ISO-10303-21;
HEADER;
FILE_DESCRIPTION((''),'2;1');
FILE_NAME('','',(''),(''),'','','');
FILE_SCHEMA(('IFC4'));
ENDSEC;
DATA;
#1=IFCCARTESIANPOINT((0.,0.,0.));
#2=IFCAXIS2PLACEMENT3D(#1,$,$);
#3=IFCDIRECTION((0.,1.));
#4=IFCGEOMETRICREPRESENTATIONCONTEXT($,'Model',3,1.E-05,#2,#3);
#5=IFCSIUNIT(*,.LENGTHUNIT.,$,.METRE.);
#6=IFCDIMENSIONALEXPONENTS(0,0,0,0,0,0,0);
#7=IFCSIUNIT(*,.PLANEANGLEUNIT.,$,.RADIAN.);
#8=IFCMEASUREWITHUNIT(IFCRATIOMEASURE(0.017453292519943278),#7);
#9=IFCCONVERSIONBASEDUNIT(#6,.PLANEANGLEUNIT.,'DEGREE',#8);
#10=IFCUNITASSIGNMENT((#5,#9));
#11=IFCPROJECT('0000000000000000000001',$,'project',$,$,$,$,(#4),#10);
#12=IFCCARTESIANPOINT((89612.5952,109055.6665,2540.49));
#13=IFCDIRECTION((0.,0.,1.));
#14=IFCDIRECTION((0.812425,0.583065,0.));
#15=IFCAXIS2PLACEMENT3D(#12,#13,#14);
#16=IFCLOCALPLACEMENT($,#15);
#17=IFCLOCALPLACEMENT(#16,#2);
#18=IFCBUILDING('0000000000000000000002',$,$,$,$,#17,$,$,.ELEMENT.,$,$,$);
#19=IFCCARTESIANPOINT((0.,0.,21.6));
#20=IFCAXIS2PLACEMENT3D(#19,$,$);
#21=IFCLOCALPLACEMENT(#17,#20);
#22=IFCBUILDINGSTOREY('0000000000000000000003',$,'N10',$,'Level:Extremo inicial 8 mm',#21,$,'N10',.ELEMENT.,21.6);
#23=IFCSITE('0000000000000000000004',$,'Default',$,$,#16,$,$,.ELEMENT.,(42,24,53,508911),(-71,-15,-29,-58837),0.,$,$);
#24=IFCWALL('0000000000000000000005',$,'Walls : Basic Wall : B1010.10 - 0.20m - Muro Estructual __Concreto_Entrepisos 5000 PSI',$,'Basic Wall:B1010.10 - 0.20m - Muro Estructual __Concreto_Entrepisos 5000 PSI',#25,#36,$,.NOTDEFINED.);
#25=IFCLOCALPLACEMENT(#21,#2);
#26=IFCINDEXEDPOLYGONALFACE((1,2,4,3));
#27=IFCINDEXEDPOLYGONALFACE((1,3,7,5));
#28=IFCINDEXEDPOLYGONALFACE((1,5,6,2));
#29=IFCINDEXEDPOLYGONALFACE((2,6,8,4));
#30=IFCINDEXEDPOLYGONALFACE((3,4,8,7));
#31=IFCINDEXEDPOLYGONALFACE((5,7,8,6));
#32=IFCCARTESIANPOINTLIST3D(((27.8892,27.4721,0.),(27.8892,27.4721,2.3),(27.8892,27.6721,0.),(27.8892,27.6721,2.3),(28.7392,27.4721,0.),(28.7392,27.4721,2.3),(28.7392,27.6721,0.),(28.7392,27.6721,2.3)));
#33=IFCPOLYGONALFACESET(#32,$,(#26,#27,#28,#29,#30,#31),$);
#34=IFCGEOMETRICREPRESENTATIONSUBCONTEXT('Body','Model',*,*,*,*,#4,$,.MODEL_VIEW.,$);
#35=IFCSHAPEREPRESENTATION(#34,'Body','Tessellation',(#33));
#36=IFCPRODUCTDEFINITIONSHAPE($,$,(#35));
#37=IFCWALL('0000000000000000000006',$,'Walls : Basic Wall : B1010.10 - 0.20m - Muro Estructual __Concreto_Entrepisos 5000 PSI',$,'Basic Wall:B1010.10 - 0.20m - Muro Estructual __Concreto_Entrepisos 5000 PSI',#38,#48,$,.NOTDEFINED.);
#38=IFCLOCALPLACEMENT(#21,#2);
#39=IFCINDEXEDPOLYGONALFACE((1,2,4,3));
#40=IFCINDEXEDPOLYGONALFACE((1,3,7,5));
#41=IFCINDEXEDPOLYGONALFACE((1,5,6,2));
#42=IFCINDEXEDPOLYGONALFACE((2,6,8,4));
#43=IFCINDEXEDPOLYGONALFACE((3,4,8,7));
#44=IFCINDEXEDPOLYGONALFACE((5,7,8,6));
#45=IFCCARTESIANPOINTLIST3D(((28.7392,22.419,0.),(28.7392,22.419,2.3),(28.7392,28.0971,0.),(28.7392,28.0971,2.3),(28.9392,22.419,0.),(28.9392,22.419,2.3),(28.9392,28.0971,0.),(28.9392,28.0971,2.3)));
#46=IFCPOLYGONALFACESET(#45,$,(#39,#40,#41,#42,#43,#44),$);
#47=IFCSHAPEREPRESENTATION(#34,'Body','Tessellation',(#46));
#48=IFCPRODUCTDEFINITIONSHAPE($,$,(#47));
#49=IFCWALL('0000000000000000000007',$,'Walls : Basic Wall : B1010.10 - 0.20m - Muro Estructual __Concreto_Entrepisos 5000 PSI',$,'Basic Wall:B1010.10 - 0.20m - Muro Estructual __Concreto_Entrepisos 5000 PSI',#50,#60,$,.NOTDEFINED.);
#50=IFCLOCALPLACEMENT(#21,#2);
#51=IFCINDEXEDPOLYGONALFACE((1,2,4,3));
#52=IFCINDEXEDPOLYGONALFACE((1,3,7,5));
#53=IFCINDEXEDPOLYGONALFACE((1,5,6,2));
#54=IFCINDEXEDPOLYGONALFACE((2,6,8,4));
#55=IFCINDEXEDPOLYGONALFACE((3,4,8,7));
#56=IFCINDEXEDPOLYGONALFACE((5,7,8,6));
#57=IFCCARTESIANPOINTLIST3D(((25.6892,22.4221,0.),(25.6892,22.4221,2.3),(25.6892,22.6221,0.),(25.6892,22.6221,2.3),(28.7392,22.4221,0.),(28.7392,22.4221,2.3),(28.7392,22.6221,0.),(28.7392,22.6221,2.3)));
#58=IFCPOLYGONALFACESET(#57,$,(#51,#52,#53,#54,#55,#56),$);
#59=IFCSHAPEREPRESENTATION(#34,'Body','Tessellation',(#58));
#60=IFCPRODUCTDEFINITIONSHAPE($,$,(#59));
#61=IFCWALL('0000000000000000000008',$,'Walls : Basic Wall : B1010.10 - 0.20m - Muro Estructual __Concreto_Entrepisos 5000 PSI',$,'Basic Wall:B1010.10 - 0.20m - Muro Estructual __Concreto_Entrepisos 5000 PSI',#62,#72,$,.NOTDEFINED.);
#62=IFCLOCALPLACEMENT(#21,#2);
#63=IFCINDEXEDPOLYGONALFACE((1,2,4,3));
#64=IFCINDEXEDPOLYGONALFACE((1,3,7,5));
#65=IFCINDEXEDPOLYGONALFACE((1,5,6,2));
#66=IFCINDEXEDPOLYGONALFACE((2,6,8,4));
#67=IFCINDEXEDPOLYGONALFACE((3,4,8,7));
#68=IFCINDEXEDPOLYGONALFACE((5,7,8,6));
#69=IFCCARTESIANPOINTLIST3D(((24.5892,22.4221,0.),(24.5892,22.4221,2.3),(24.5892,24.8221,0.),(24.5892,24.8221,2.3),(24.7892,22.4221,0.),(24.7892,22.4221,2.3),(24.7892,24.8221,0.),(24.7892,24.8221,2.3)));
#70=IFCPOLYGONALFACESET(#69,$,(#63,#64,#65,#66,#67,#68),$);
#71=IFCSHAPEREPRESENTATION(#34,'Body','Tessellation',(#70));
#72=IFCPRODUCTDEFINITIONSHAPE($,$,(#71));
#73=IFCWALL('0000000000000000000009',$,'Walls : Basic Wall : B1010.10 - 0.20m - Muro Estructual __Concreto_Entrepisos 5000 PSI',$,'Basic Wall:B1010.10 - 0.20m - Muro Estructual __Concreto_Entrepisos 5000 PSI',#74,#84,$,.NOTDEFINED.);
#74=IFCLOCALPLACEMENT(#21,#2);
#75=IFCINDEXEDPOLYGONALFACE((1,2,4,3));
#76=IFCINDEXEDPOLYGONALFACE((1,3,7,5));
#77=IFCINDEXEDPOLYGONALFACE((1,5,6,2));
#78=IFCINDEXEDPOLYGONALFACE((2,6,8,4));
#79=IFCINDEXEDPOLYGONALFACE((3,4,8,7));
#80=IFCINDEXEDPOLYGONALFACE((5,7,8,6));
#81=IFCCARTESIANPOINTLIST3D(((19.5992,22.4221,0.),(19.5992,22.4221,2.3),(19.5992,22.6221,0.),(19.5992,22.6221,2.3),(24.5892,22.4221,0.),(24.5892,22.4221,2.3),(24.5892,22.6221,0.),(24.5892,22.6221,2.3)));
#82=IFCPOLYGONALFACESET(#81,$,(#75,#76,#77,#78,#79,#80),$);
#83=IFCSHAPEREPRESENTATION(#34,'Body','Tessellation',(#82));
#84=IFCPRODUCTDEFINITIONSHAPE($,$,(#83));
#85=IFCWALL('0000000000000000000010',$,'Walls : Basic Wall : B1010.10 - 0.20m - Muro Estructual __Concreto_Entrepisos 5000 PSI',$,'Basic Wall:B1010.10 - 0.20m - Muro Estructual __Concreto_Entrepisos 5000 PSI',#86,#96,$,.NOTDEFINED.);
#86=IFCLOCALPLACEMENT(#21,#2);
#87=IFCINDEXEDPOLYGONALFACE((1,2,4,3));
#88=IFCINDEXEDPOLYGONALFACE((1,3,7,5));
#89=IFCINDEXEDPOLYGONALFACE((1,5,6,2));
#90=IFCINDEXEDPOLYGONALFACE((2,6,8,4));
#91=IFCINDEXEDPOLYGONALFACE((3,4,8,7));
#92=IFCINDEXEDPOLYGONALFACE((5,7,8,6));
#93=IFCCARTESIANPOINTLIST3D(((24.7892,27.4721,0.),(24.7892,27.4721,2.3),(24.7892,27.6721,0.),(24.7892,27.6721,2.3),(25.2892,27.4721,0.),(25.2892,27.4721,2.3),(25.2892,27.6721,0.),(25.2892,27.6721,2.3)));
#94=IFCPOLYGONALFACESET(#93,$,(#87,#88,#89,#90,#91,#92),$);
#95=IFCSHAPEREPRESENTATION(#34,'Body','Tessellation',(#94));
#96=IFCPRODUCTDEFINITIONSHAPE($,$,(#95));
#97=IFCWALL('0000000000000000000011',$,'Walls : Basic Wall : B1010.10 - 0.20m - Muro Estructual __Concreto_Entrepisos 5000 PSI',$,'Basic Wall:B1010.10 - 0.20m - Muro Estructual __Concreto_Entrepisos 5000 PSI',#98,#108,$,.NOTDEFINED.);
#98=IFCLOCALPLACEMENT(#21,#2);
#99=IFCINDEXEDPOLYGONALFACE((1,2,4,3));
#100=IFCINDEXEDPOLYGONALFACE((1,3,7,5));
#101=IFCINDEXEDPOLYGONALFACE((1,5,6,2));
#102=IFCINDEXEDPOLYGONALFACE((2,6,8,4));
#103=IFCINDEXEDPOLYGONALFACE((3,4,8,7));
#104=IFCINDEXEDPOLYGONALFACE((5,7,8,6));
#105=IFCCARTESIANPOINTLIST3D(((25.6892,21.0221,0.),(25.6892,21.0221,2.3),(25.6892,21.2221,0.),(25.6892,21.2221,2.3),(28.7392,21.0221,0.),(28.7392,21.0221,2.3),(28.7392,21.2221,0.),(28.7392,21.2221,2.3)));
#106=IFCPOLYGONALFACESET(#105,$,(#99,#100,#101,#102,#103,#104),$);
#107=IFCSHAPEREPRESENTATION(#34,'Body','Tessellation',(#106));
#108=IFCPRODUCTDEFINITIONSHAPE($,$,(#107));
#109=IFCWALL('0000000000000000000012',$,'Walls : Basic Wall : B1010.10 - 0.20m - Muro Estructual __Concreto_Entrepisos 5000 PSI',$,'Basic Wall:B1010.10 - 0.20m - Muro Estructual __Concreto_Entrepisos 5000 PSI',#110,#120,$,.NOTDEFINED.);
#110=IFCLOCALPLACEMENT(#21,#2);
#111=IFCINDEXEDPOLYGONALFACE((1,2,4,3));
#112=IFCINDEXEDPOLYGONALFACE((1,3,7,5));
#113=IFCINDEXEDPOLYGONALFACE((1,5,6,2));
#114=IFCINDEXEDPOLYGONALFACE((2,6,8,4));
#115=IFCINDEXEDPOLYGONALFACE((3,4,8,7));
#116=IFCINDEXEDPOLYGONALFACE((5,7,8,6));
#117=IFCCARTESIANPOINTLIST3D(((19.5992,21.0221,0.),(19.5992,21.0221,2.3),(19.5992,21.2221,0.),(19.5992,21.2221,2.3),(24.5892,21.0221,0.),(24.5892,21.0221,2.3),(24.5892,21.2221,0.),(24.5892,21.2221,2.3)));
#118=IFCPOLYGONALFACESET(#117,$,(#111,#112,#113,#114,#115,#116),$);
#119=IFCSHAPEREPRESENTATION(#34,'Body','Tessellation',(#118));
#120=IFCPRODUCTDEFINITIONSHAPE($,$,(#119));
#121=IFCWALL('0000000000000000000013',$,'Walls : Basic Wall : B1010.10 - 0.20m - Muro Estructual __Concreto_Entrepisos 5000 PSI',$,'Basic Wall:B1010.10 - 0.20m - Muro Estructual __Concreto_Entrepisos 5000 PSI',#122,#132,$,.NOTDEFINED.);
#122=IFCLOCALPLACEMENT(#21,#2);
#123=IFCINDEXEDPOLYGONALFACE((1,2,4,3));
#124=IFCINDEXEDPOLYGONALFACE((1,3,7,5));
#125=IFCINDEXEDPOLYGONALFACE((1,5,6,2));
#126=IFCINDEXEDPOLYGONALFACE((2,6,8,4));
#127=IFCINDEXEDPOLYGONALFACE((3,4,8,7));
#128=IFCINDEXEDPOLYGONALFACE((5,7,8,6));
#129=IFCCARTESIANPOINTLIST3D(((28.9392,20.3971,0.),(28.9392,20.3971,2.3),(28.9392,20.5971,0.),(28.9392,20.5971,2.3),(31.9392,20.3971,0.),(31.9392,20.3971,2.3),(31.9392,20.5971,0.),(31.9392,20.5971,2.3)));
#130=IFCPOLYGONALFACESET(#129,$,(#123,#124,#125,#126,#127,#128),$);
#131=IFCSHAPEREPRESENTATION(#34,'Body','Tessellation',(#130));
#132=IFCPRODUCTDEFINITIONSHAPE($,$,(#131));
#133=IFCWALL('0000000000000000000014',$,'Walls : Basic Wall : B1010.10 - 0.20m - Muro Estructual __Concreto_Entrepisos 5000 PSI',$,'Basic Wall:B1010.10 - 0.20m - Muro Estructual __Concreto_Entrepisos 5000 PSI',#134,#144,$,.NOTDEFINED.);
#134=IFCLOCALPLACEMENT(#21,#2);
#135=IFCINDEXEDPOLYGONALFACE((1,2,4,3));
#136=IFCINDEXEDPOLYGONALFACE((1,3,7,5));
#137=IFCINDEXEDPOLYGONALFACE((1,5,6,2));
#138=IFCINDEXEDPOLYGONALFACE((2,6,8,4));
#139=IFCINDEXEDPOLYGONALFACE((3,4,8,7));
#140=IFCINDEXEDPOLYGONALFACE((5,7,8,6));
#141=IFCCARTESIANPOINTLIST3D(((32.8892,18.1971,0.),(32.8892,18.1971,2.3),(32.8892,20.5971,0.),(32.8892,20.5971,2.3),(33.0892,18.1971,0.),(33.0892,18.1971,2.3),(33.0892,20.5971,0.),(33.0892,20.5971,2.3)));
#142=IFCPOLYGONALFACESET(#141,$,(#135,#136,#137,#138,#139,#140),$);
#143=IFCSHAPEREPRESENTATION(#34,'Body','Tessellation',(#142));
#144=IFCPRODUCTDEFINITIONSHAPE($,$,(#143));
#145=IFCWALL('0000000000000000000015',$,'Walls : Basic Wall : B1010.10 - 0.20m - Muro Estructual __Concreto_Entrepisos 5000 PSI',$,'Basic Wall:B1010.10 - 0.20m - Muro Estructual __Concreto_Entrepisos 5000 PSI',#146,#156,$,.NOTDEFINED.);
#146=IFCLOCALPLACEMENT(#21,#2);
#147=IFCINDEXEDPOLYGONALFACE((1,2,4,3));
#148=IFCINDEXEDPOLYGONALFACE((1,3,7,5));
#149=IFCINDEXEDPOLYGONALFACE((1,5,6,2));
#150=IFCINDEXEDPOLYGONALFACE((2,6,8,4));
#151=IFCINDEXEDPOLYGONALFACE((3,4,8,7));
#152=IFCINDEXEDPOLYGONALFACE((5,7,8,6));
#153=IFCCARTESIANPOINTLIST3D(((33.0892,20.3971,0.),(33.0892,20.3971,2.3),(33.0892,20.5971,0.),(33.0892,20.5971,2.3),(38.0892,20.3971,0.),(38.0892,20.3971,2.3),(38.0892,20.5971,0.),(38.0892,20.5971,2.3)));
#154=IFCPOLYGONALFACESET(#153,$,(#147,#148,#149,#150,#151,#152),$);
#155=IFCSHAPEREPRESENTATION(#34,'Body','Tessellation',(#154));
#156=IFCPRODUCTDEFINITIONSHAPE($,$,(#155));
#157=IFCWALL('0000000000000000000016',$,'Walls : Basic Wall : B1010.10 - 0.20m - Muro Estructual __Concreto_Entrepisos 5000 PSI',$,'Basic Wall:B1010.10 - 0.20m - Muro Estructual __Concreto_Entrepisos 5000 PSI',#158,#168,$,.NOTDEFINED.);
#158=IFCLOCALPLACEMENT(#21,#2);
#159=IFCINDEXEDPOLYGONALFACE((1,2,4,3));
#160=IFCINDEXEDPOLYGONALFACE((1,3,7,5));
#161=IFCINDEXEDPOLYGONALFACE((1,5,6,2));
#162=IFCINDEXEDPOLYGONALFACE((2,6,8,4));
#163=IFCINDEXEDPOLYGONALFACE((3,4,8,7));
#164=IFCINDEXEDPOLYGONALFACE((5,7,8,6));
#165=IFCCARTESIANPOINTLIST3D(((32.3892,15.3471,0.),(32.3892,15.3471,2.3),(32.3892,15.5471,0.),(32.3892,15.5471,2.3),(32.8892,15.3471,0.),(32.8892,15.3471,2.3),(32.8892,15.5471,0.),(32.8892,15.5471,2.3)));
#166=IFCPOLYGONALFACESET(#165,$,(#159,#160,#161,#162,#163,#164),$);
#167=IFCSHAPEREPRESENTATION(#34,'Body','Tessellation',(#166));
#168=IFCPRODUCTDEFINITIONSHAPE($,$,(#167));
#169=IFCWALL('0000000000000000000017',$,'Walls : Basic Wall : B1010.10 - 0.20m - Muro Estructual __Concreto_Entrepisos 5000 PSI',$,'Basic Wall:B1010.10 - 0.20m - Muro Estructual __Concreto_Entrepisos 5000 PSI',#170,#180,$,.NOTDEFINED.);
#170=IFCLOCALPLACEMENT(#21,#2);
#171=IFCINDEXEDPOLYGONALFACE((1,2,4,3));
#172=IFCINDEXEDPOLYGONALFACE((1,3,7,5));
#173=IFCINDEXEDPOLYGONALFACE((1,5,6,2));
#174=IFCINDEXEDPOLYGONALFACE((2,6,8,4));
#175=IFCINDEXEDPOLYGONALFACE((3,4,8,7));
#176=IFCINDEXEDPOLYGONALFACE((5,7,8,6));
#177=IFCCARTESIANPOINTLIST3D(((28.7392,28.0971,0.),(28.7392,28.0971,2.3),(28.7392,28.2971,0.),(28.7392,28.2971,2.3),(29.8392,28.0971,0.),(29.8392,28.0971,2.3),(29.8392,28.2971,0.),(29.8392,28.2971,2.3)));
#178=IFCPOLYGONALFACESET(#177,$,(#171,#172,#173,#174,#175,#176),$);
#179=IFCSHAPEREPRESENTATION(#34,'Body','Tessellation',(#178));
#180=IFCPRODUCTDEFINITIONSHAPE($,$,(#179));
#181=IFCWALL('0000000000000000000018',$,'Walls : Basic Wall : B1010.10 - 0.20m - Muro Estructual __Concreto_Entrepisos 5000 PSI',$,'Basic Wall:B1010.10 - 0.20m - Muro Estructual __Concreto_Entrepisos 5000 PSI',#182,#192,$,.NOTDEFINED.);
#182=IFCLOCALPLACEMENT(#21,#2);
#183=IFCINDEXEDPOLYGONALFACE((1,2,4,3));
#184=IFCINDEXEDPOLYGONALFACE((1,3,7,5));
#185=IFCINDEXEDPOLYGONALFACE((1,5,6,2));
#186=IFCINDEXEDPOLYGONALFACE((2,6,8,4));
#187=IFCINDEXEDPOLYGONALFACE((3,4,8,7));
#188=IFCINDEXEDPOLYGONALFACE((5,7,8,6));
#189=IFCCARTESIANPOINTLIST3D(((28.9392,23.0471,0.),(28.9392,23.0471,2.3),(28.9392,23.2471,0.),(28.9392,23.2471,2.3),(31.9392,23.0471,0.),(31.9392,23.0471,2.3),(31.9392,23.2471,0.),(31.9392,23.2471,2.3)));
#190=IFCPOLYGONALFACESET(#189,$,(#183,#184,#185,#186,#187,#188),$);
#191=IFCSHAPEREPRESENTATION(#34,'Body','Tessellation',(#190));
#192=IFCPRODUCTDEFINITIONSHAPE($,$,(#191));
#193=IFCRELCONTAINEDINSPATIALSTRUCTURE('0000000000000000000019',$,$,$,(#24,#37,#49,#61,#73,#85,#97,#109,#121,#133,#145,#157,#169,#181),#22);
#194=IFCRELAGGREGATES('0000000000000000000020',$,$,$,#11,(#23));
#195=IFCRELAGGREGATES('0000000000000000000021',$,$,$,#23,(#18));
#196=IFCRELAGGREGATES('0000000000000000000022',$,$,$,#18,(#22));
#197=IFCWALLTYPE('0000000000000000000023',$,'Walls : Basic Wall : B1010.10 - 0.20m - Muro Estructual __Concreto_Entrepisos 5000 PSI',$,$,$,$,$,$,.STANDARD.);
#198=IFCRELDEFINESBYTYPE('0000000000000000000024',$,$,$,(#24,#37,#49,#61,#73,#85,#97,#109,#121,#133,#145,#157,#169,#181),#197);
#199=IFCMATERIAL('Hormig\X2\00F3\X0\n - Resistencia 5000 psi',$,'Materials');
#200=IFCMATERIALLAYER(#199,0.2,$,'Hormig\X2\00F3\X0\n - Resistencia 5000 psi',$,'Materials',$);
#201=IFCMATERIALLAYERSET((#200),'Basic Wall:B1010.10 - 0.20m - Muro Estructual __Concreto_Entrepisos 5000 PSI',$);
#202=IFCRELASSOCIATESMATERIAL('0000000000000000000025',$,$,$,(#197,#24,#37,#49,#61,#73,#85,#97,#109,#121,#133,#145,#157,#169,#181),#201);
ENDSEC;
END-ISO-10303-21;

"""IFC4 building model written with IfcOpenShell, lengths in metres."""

from ifc_helpers import new_model, entity, si_unit, converted_unit, direction, frame, frame_2d, origin, place, context, subcontext, project, spatial, rectangle, extrude, material, layer, layer_set, layer_usage, type_object, element, save


model = new_model("IFC4")

# Units and contexts
model_context = context("Model", 3, precision=1e-05, world=origin(), true_north=direction((0.0, 1.0)))
body_context = subcontext(model_context, "Body", "Model", "MODEL_VIEW")
ifc_project = project(units=[si_unit("LENGTHUNIT", "METRE"), converted_unit("PLANEANGLEUNIT", "DEGREE", entity("IfcRatioMeasure", 0.017453292519943278), si_unit("PLANEANGLEUNIT", "RADIAN"), dimensions=[0, 0, 0, 0, 0, 0, 0])], contexts=[model_context])

# Site, building, storey
site_placement = place(None, frame((89612.5952, 109055.6665, 2540.49), z_axis=(0.0, 0.0, 1.0), x_axis=(0.812425, 0.583065, 0.0)))
site = spatial("IfcSite", under=ifc_project, at=site_placement, Name="Default", CompositionType="ELEMENT", RefLatitude=(42, 24, 53, 508911), RefLongitude=(-71, -15, -29, -58837), RefElevation=0.0)
building_placement = place(site_placement, origin())
building = spatial("IfcBuilding", under=site, at=building_placement, CompositionType="ELEMENT")
storey_placement = place(building_placement, frame((0.0, 0.0, 21.6)))
storey = spatial("IfcBuildingStorey", under=building, at=storey_placement, Name="N10", ObjectType="Level:Extremo inicial 8 mm", LongName="N10", CompositionType="ELEMENT", Elevation=21.6)

# Walls
ifc_material = material(Name="Hormigón - Resistencia 5000 psi", Category="Materials")
ifc_layer_1 = layer(ifc_material, 0.2, Name="Hormigón - Resistencia 5000 psi", Category="Materials")
ifc_layer_set_1 = layer_set([ifc_layer_1], Name="Basic Wall:B1010.10 - 0.20m - Muro Estructual __Concreto_Entrepisos 5000 PSI")
ifc_layer_usage_1 = layer_usage(ifc_layer_set_1, "AXIS2", "NEGATIVE", 0.1)
wall_type_1 = type_object("IfcWallType", Name="Walls : Basic Wall : B1010.10 - 0.20m - Muro Estructual __Concreto_Entrepisos 5000 PSI", PredefinedType="STANDARD", material=ifc_layer_set_1)
wall_1_placement = place(storey_placement, frame((27.8892, 27.5721, 0.0)))
element("IfcWall", 1, at=wall_1_placement, inside=storey, type_object=wall_type_1, material=ifc_layer_usage_1, Name="Walls : Basic Wall : B1010.10 - 0.20m - Muro Estructual __Concreto_Entrepisos 5000 PSI", ObjectType="Basic Wall:B1010.10 - 0.20m - Muro Estructual __Concreto_Entrepisos 5000 PSI", PredefinedType="NOTDEFINED", context=body_context, shape_type="SweptSolid", body=[
    extrude(rectangle(XDim=0.85, YDim=0.2, at=frame_2d((0.425, 0.0), x_axis=(-1.0, 0.0))), origin(), (0.0, 0.0, 1.0), 2.3),
])
ifc_layer_usage_2 = layer_usage(ifc_layer_set_1, "AXIS2", "NEGATIVE", 0.1)
wall_2_placement = place(storey_placement, frame((28.8392, 28.0971, 0.0), z_axis=(0.0, 0.0, 1.0), x_axis=(0.0, -1.0, 0.0)))
element("IfcWall", 2, at=wall_2_placement, inside=storey, type_object=wall_type_1, material=ifc_layer_usage_2, Name="Walls : Basic Wall : B1010.10 - 0.20m - Muro Estructual __Concreto_Entrepisos 5000 PSI", ObjectType="Basic Wall:B1010.10 - 0.20m - Muro Estructual __Concreto_Entrepisos 5000 PSI", PredefinedType="NOTDEFINED", context=body_context, shape_type="SweptSolid", body=[
    extrude(rectangle(XDim=5.6781, YDim=0.2, at=frame_2d((2.839, 0.0), x_axis=(-1.0, 0.0))), origin(), (0.0, 0.0, 1.0), 2.3),
])
ifc_layer_usage_3 = layer_usage(ifc_layer_set_1, "AXIS2", "NEGATIVE", 0.1)
wall_3_placement = place(storey_placement, frame((28.7392, 22.5221, 0.0), z_axis=(0.0, 0.0, 1.0), x_axis=(-1.0, 0.0, 0.0)))
element("IfcWall", 3, at=wall_3_placement, inside=storey, type_object=wall_type_1, material=ifc_layer_usage_3, Name="Walls : Basic Wall : B1010.10 - 0.20m - Muro Estructual __Concreto_Entrepisos 5000 PSI", ObjectType="Basic Wall:B1010.10 - 0.20m - Muro Estructual __Concreto_Entrepisos 5000 PSI", PredefinedType="NOTDEFINED", context=body_context, shape_type="SweptSolid", body=[
    extrude(rectangle(XDim=3.05, YDim=0.2, at=frame_2d((1.525, 0.0), x_axis=(-1.0, 0.0))), origin(), (0.0, 0.0, 1.0), 2.3),
])
ifc_layer_usage_4 = layer_usage(ifc_layer_set_1, "AXIS2", "NEGATIVE", 0.1)
wall_4_placement = place(storey_placement, frame((24.6892, 24.8221, 0.0), z_axis=(0.0, 0.0, 1.0), x_axis=(0.0, -1.0, 0.0)))
element("IfcWall", 4, at=wall_4_placement, inside=storey, type_object=wall_type_1, material=ifc_layer_usage_4, Name="Walls : Basic Wall : B1010.10 - 0.20m - Muro Estructual __Concreto_Entrepisos 5000 PSI", ObjectType="Basic Wall:B1010.10 - 0.20m - Muro Estructual __Concreto_Entrepisos 5000 PSI", PredefinedType="NOTDEFINED", context=body_context, shape_type="SweptSolid", body=[
    extrude(rectangle(XDim=2.4, YDim=0.2, at=frame_2d((1.2, 0.0), x_axis=(-1.0, 0.0))), origin(), (0.0, 0.0, 1.0), 2.3),
])
ifc_layer_usage_5 = layer_usage(ifc_layer_set_1, "AXIS2", "NEGATIVE", 0.1)
wall_5_placement = place(storey_placement, frame((24.5892, 22.5221, 0.0), z_axis=(0.0, 0.0, 1.0), x_axis=(-1.0, 0.0, 0.0)))
element("IfcWall", 5, at=wall_5_placement, inside=storey, type_object=wall_type_1, material=ifc_layer_usage_5, Name="Walls : Basic Wall : B1010.10 - 0.20m - Muro Estructual __Concreto_Entrepisos 5000 PSI", ObjectType="Basic Wall:B1010.10 - 0.20m - Muro Estructual __Concreto_Entrepisos 5000 PSI", PredefinedType="NOTDEFINED", context=body_context, shape_type="SweptSolid", body=[
    extrude(rectangle(XDim=4.99, YDim=0.2, at=frame_2d((2.495, 0.0), x_axis=(-1.0, 0.0))), origin(), (0.0, 0.0, 1.0), 2.3),
])
ifc_layer_usage_6 = layer_usage(ifc_layer_set_1, "AXIS2", "NEGATIVE", 0.1)
wall_6_placement = place(storey_placement, frame((25.2892, 27.5721, 0.0), z_axis=(0.0, 0.0, 1.0), x_axis=(-1.0, 0.0, 0.0)))
element("IfcWall", 6, at=wall_6_placement, inside=storey, type_object=wall_type_1, material=ifc_layer_usage_6, Name="Walls : Basic Wall : B1010.10 - 0.20m - Muro Estructual __Concreto_Entrepisos 5000 PSI", ObjectType="Basic Wall:B1010.10 - 0.20m - Muro Estructual __Concreto_Entrepisos 5000 PSI", PredefinedType="NOTDEFINED", context=body_context, shape_type="SweptSolid", body=[
    extrude(rectangle(XDim=0.5, YDim=0.2, at=frame_2d((0.25, 0.0), x_axis=(-1.0, 0.0))), origin(), (0.0, 0.0, 1.0), 2.3),
])
ifc_layer_usage_7 = layer_usage(ifc_layer_set_1, "AXIS2", "POSITIVE", -0.1)
wall_7_placement = place(storey_placement, frame((28.7392, 21.1221, 0.0), z_axis=(0.0, 0.0, 1.0), x_axis=(-1.0, 0.0, 0.0)))
element("IfcWall", 7, at=wall_7_placement, inside=storey, type_object=wall_type_1, material=ifc_layer_usage_7, Name="Walls : Basic Wall : B1010.10 - 0.20m - Muro Estructual __Concreto_Entrepisos 5000 PSI", ObjectType="Basic Wall:B1010.10 - 0.20m - Muro Estructual __Concreto_Entrepisos 5000 PSI", PredefinedType="NOTDEFINED", context=body_context, shape_type="SweptSolid", body=[
    extrude(rectangle(XDim=3.05, YDim=0.2, at=frame_2d((1.525, 0.0), x_axis=(-1.0, 0.0))), origin(), (0.0, 0.0, 1.0), 2.3),
])
ifc_layer_usage_8 = layer_usage(ifc_layer_set_1, "AXIS2", "POSITIVE", -0.1)
wall_8_placement = place(storey_placement, frame((24.5892, 21.1221, 0.0), z_axis=(0.0, 0.0, 1.0), x_axis=(-1.0, 0.0, 0.0)))
element("IfcWall", 8, at=wall_8_placement, inside=storey, type_object=wall_type_1, material=ifc_layer_usage_8, Name="Walls : Basic Wall : B1010.10 - 0.20m - Muro Estructual __Concreto_Entrepisos 5000 PSI", ObjectType="Basic Wall:B1010.10 - 0.20m - Muro Estructual __Concreto_Entrepisos 5000 PSI", PredefinedType="NOTDEFINED", context=body_context, shape_type="SweptSolid", body=[
    extrude(rectangle(XDim=4.99, YDim=0.2, at=frame_2d((2.495, 0.0), x_axis=(-1.0, 0.0))), origin(), (0.0, 0.0, 1.0), 2.3),
])
ifc_layer_usage_9 = layer_usage(ifc_layer_set_1, "AXIS2", "NEGATIVE", 0.1)
wall_9_placement = place(storey_placement, frame((28.9392, 20.4971, 0.0)))
element("IfcWall", 9, at=wall_9_placement, inside=storey, type_object=wall_type_1, material=ifc_layer_usage_9, Name="Walls : Basic Wall : B1010.10 - 0.20m - Muro Estructual __Concreto_Entrepisos 5000 PSI", ObjectType="Basic Wall:B1010.10 - 0.20m - Muro Estructual __Concreto_Entrepisos 5000 PSI", PredefinedType="NOTDEFINED", context=body_context, shape_type="SweptSolid", body=[
    extrude(rectangle(XDim=3.0, YDim=0.2, at=frame_2d((1.5, 0.0), x_axis=(-1.0, 0.0))), origin(), (0.0, 0.0, 1.0), 2.3),
])
ifc_layer_usage_10 = layer_usage(ifc_layer_set_1, "AXIS2", "NEGATIVE", 0.1)
wall_10_placement = place(storey_placement, frame((32.9892, 18.1971, 0.0), z_axis=(0.0, 0.0, 1.0), x_axis=(0.0, 1.0, 0.0)))
element("IfcWall", 10, at=wall_10_placement, inside=storey, type_object=wall_type_1, material=ifc_layer_usage_10, Name="Walls : Basic Wall : B1010.10 - 0.20m - Muro Estructual __Concreto_Entrepisos 5000 PSI", ObjectType="Basic Wall:B1010.10 - 0.20m - Muro Estructual __Concreto_Entrepisos 5000 PSI", PredefinedType="NOTDEFINED", context=body_context, shape_type="SweptSolid", body=[
    extrude(rectangle(XDim=2.4, YDim=0.2, at=frame_2d((1.2, 0.0), x_axis=(-1.0, 0.0))), origin(), (0.0, 0.0, 1.0), 2.3),
])
ifc_layer_usage_11 = layer_usage(ifc_layer_set_1, "AXIS2", "NEGATIVE", 0.1)
wall_11_placement = place(storey_placement, frame((33.0892, 20.4971, 0.0)))
element("IfcWall", 11, at=wall_11_placement, inside=storey, type_object=wall_type_1, material=ifc_layer_usage_11, Name="Walls : Basic Wall : B1010.10 - 0.20m - Muro Estructual __Concreto_Entrepisos 5000 PSI", ObjectType="Basic Wall:B1010.10 - 0.20m - Muro Estructual __Concreto_Entrepisos 5000 PSI", PredefinedType="NOTDEFINED", context=body_context, shape_type="SweptSolid", body=[
    extrude(rectangle(XDim=5.0, YDim=0.2, at=frame_2d((2.5, 0.0), x_axis=(-1.0, 0.0))), origin(), (0.0, 0.0, 1.0), 2.3),
])
ifc_layer_usage_12 = layer_usage(ifc_layer_set_1, "AXIS2", "NEGATIVE", 0.1)
wall_12_placement = place(storey_placement, frame((32.3892, 15.4471, 0.0)))
element("IfcWall", 12, at=wall_12_placement, inside=storey, type_object=wall_type_1, material=ifc_layer_usage_12, Name="Walls : Basic Wall : B1010.10 - 0.20m - Muro Estructual __Concreto_Entrepisos 5000 PSI", ObjectType="Basic Wall:B1010.10 - 0.20m - Muro Estructual __Concreto_Entrepisos 5000 PSI", PredefinedType="NOTDEFINED", context=body_context, shape_type="SweptSolid", body=[
    extrude(rectangle(XDim=0.5, YDim=0.2, at=frame_2d((0.25, 0.0), x_axis=(-1.0, 0.0))), origin(), (0.0, 0.0, 1.0), 2.3),
])
ifc_layer_usage_13 = layer_usage(ifc_layer_set_1, "AXIS2", "POSITIVE", -0.1)
wall_13_placement = place(storey_placement, frame((29.8392, 28.1971, 0.0), z_axis=(0.0, 0.0, 1.0), x_axis=(-1.0, 0.0, 0.0)))
element("IfcWall", 13, at=wall_13_placement, inside=storey, type_object=wall_type_1, material=ifc_layer_usage_13, Name="Walls : Basic Wall : B1010.10 - 0.20m - Muro Estructual __Concreto_Entrepisos 5000 PSI", ObjectType="Basic Wall:B1010.10 - 0.20m - Muro Estructual __Concreto_Entrepisos 5000 PSI", PredefinedType="NOTDEFINED", context=body_context, shape_type="SweptSolid", body=[
    extrude(rectangle(XDim=1.1, YDim=0.2, at=frame_2d((0.55, 0.0), x_axis=(-1.0, 0.0))), origin(), (0.0, 0.0, 1.0), 2.3),
])
ifc_layer_usage_14 = layer_usage(ifc_layer_set_1, "AXIS2", "POSITIVE", -0.1)
wall_14_placement = place(storey_placement, frame((28.9392, 23.1471, 0.0)))
element("IfcWall", 14, at=wall_14_placement, inside=storey, type_object=wall_type_1, material=ifc_layer_usage_14, Name="Walls : Basic Wall : B1010.10 - 0.20m - Muro Estructual __Concreto_Entrepisos 5000 PSI", ObjectType="Basic Wall:B1010.10 - 0.20m - Muro Estructual __Concreto_Entrepisos 5000 PSI", PredefinedType="NOTDEFINED", context=body_context, shape_type="SweptSolid", body=[
    extrude(rectangle(XDim=3.0, YDim=0.2, at=frame_2d((1.5, 0.0), x_axis=(-1.0, 0.0))), origin(), (0.0, 0.0, 1.0), 2.3),
])

save(model, "model.ifc")
